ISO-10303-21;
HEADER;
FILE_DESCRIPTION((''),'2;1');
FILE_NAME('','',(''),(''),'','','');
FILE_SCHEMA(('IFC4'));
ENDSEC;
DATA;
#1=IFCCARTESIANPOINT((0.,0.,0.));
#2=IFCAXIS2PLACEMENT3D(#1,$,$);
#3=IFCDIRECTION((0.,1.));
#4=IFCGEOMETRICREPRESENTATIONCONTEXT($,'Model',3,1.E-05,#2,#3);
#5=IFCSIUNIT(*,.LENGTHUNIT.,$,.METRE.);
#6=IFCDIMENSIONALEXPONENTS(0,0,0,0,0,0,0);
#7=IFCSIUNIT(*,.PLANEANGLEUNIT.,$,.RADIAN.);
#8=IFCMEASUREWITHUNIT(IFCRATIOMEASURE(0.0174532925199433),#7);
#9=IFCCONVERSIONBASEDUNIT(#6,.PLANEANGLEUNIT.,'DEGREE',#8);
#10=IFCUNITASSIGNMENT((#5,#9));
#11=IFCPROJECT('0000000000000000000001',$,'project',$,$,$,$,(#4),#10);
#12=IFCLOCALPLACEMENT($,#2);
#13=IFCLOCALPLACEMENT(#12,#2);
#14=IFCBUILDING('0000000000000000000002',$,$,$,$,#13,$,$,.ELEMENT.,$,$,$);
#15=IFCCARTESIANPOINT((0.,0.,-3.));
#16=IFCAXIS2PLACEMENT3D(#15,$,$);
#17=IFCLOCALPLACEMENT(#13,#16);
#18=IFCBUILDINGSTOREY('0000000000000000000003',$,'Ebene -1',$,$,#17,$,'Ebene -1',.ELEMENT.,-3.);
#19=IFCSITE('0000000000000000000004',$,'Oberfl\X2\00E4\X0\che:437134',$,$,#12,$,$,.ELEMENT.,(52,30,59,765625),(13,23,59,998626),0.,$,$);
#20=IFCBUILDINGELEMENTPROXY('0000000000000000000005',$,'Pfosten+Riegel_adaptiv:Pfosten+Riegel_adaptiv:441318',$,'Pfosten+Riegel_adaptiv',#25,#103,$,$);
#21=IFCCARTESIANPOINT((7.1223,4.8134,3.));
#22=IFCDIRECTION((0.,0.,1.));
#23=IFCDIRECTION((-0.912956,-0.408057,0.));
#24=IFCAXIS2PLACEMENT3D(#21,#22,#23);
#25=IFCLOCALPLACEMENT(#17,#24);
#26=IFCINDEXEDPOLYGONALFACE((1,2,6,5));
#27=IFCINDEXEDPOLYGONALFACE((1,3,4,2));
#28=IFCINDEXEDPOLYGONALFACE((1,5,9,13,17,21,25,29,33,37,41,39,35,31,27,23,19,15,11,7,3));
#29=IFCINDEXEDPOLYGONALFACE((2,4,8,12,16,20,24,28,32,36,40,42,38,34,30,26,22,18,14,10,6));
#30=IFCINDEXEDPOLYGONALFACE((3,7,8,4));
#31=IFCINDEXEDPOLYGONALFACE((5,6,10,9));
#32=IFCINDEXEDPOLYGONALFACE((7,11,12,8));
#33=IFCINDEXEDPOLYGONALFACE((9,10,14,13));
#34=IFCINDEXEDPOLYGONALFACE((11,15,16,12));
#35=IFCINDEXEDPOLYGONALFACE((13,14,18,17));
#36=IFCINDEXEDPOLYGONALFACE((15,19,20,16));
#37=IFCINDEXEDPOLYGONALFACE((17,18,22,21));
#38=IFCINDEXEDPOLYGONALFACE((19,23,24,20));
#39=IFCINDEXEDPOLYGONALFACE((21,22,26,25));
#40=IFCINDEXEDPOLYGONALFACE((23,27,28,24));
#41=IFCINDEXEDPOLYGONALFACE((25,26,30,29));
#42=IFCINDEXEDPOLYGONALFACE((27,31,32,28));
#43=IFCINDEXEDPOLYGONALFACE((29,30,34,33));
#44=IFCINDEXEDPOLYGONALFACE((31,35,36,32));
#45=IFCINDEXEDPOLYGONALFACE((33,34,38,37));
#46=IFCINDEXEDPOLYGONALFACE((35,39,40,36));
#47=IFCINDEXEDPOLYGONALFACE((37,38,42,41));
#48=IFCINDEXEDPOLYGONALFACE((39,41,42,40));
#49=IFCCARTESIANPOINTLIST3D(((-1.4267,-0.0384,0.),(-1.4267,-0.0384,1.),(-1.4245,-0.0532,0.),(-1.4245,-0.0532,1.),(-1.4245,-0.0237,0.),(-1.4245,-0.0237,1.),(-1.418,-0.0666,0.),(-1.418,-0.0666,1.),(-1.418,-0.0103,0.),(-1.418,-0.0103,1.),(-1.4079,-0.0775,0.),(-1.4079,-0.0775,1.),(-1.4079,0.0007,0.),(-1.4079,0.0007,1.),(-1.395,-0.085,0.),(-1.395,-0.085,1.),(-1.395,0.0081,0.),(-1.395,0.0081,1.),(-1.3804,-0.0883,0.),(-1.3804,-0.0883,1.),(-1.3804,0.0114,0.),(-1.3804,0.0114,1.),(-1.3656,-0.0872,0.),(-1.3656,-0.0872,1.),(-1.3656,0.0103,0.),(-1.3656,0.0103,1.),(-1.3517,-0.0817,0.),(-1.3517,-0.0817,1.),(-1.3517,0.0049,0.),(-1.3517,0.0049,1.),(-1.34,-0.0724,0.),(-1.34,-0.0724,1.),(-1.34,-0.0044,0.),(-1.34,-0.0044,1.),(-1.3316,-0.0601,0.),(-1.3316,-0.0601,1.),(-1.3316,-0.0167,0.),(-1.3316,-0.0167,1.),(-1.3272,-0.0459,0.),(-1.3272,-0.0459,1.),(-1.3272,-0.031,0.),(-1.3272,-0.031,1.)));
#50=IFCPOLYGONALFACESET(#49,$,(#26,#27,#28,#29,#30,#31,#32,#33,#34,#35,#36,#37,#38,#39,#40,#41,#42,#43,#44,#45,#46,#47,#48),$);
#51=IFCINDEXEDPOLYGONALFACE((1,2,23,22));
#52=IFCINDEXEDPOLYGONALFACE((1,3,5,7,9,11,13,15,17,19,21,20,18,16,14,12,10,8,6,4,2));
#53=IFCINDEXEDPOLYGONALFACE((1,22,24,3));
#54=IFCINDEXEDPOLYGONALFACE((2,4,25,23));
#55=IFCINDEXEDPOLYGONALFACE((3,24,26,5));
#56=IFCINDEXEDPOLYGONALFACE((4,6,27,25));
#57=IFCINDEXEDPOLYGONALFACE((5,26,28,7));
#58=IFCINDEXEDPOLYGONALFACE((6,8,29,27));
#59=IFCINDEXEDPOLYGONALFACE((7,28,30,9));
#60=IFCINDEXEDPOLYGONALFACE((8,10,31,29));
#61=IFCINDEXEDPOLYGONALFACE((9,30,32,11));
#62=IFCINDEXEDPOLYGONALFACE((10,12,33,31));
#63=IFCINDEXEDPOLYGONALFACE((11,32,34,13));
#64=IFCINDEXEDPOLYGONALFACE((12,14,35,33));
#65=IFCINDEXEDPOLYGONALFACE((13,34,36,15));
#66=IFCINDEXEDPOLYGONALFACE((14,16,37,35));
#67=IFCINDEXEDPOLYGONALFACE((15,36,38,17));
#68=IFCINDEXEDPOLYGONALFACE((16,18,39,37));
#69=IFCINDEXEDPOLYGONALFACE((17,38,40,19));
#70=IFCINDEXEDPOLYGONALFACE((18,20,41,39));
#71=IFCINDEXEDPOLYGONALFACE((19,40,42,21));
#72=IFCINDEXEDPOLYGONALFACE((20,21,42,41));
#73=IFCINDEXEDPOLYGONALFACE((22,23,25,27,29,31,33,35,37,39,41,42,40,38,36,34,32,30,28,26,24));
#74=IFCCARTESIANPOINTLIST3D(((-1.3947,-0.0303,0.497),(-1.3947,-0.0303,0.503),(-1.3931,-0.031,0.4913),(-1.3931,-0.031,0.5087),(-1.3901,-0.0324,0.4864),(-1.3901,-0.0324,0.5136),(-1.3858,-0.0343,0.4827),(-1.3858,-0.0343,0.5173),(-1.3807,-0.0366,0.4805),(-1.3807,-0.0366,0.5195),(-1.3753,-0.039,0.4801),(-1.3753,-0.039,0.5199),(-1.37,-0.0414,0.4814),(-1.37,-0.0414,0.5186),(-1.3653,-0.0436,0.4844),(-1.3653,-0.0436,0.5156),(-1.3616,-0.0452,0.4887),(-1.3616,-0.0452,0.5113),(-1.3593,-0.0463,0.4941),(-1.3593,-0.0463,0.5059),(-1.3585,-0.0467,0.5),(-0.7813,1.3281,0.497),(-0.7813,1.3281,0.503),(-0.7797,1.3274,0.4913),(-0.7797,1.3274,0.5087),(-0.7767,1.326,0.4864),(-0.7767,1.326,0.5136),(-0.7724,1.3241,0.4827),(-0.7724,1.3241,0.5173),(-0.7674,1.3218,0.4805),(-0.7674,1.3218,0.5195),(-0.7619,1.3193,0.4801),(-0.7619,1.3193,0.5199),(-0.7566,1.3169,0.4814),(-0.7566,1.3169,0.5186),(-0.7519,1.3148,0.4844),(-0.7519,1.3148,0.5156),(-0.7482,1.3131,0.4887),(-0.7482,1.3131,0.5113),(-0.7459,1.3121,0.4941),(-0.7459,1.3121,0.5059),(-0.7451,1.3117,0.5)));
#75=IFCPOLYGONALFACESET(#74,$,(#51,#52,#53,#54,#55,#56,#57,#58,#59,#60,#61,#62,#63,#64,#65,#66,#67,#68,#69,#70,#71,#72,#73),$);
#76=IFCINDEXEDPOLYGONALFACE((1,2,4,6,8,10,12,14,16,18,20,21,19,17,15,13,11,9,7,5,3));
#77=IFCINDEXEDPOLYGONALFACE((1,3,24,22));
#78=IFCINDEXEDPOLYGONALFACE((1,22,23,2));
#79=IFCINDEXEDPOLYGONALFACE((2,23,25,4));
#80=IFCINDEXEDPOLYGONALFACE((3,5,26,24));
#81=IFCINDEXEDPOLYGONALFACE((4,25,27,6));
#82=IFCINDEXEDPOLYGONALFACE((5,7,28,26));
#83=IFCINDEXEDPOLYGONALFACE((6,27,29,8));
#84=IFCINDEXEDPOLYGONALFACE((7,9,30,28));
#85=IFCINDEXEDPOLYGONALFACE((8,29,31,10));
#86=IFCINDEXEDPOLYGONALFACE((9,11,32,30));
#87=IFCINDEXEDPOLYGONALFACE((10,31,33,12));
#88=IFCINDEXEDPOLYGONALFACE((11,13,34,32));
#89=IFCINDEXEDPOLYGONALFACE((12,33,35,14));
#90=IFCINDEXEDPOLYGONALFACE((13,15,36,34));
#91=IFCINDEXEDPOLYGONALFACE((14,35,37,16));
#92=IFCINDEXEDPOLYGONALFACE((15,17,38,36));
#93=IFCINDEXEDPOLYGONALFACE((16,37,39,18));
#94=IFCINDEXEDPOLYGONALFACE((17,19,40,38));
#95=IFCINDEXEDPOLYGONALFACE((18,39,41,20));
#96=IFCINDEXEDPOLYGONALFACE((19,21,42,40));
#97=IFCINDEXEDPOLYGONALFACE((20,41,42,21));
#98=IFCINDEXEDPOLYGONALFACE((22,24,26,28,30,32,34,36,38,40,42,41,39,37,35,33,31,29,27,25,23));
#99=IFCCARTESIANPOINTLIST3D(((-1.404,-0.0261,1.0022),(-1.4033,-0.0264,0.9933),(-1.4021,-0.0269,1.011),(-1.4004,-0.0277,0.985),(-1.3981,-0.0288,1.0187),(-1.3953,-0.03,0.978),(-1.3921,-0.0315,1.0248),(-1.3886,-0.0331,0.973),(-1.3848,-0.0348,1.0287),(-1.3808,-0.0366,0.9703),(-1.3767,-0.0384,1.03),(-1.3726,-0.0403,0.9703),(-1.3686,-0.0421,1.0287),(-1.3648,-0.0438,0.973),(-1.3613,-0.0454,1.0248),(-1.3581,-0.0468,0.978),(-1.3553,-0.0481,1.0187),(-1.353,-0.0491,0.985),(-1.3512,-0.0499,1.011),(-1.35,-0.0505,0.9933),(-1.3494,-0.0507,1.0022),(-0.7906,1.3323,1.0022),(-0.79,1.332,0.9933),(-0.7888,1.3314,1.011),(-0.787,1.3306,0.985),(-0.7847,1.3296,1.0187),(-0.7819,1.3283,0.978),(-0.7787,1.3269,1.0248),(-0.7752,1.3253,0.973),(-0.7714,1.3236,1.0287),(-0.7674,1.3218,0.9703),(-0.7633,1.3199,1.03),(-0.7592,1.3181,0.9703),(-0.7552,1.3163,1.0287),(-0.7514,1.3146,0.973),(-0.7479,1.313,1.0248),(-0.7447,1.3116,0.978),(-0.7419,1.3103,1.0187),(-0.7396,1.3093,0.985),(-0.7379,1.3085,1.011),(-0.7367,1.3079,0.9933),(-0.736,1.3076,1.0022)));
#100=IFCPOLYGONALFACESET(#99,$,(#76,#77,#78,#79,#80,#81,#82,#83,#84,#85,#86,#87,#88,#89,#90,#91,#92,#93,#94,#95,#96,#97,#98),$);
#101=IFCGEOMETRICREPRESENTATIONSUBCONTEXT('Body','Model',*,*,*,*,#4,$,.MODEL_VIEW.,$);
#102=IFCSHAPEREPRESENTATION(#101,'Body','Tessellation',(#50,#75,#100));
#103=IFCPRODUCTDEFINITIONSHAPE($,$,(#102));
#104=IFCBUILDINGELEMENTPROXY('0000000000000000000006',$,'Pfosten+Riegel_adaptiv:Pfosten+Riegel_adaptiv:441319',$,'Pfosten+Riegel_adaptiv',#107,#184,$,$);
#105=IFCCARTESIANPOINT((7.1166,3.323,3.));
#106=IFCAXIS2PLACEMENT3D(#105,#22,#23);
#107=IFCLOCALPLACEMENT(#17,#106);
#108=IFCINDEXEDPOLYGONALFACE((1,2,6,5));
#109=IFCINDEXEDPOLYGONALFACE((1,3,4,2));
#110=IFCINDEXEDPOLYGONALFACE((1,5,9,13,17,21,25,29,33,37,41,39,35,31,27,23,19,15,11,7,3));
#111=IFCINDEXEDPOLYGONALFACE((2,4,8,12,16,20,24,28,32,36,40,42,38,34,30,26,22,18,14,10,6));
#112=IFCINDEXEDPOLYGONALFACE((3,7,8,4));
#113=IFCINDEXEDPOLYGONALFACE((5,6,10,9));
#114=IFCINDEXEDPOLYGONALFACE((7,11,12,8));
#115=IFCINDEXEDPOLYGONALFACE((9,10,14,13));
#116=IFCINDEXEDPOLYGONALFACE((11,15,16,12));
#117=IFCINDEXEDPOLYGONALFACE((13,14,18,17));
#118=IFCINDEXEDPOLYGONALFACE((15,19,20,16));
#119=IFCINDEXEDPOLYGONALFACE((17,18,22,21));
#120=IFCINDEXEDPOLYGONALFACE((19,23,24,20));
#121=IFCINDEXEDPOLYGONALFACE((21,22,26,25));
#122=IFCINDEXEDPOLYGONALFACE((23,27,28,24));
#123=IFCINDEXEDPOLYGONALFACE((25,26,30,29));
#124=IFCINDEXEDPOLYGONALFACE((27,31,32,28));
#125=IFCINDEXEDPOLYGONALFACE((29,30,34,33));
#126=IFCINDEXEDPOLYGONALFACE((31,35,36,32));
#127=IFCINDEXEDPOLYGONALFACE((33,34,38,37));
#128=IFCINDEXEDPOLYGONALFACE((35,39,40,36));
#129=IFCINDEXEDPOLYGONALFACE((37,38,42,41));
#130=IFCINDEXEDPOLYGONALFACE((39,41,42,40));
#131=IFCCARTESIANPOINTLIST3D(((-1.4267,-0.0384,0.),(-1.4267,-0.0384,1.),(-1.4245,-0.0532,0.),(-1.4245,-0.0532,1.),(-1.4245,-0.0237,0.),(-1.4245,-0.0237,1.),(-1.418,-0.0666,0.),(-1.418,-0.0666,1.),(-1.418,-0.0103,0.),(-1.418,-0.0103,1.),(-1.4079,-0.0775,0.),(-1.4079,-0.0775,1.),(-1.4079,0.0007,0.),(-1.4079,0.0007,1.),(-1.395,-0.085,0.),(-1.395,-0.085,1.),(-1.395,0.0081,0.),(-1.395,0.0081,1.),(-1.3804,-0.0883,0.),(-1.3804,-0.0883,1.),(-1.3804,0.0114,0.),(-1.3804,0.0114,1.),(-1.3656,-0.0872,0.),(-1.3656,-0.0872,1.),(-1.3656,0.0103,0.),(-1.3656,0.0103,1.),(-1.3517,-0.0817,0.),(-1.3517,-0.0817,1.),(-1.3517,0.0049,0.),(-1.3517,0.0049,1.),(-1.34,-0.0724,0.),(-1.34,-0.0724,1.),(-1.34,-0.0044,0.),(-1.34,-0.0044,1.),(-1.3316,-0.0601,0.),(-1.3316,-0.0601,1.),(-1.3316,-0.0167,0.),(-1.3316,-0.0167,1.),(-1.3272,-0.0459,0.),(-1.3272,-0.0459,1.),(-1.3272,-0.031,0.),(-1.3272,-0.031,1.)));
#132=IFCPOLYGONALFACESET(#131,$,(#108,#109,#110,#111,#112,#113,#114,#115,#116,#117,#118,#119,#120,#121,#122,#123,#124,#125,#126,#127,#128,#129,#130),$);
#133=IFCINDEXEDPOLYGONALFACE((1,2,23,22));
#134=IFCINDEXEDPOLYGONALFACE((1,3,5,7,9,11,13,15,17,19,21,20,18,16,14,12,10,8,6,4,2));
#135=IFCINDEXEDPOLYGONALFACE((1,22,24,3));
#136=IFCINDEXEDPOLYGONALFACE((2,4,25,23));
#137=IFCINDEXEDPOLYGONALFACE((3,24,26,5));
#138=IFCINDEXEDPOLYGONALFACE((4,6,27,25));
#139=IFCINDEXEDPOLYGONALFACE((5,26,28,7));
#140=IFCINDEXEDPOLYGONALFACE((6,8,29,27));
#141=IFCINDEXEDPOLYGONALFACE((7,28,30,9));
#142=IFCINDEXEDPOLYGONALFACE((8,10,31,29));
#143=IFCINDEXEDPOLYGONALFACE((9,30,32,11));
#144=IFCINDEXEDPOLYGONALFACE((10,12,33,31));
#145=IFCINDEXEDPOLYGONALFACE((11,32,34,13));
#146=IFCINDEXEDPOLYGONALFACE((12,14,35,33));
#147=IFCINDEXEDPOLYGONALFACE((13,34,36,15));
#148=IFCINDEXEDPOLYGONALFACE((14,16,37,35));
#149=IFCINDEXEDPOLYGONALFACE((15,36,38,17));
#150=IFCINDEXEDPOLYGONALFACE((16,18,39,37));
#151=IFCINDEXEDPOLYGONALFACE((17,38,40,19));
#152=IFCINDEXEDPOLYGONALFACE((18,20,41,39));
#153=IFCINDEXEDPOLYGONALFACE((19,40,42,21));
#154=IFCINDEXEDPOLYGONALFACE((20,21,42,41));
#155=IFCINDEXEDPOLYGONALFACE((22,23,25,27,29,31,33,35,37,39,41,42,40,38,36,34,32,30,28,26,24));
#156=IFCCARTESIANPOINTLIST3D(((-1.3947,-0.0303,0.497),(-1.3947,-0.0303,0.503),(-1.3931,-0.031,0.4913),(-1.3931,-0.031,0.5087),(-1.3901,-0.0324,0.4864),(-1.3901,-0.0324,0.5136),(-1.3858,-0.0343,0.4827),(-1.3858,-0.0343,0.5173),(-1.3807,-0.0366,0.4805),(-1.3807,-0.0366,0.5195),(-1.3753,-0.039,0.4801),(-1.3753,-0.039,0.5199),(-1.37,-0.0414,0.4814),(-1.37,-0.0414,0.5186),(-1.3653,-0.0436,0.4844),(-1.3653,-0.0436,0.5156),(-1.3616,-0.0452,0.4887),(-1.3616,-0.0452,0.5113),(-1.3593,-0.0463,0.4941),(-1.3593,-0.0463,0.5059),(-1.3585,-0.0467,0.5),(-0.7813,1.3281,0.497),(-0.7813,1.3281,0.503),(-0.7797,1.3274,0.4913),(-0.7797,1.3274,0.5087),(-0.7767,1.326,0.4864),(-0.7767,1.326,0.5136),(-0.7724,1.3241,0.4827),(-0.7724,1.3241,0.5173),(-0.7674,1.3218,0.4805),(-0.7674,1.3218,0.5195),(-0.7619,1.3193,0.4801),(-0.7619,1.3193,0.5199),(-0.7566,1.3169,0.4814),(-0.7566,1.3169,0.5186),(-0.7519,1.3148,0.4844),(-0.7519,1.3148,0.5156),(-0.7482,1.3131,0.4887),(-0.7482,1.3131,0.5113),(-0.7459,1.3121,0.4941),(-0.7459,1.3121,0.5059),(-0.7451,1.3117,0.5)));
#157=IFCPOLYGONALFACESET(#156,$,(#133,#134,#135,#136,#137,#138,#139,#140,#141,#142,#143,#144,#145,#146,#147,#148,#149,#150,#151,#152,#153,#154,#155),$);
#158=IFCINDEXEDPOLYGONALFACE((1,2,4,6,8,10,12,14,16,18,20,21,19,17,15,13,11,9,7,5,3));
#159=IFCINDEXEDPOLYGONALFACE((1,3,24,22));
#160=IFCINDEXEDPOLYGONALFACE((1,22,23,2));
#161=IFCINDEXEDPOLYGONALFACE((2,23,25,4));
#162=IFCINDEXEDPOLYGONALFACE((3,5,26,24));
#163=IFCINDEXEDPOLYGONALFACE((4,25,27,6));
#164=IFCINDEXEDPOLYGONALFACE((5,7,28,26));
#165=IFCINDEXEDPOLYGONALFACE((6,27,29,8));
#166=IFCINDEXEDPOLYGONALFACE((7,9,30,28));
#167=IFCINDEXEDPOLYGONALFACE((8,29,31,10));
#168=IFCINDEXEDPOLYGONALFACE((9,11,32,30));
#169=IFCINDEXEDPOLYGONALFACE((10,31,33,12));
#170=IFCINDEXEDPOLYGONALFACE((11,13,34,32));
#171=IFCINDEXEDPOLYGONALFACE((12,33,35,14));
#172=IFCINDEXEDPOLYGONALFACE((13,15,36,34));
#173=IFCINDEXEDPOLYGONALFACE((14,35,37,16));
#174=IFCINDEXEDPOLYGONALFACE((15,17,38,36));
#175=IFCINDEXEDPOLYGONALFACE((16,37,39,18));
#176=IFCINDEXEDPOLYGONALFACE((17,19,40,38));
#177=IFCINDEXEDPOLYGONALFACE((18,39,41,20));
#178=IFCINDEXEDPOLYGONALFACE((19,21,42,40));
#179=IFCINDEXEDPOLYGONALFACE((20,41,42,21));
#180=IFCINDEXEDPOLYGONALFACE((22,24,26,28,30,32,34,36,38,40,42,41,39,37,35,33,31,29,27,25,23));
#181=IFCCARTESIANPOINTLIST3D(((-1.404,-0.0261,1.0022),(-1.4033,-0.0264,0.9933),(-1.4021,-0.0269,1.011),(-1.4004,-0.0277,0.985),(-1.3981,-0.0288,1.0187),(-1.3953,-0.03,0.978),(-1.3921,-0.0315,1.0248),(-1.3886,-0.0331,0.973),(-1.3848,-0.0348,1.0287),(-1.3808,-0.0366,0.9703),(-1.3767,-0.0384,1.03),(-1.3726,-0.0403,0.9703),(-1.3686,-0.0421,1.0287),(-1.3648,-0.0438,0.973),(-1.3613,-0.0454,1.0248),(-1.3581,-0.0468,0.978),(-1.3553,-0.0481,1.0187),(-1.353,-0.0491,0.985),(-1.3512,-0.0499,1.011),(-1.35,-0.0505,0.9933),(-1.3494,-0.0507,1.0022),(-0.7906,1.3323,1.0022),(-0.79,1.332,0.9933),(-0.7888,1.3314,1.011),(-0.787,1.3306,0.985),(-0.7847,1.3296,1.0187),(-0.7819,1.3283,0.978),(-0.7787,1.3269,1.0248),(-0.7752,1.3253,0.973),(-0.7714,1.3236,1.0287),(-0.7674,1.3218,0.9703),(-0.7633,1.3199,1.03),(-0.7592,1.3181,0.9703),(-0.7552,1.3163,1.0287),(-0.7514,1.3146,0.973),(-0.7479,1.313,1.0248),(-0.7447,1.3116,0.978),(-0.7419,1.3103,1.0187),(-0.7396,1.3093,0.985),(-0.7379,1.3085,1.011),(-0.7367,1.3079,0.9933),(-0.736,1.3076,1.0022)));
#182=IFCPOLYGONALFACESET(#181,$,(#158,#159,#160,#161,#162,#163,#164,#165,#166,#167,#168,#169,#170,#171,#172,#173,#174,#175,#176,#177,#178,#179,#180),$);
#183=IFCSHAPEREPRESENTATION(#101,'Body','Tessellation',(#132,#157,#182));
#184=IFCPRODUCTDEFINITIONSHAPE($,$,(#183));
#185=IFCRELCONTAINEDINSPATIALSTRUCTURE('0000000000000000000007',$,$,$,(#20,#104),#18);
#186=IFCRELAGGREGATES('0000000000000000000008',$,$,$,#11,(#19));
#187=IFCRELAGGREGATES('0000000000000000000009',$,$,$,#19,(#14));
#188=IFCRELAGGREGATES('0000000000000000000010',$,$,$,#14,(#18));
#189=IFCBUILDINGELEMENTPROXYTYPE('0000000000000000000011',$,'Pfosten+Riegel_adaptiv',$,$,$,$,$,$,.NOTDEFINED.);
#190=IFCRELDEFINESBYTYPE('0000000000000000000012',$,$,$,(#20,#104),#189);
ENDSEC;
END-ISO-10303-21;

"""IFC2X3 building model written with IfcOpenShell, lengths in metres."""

from ifc_helpers import new_model, entity, si_unit, converted_unit, direction, frame, frame_2d, origin, place, context, subcontext, project, spatial, circle, extrude, source, transform, mapped, type_object, type_shapes, element, save


model = new_model("IFC2X3")

# Units and contexts
model_context = context("Model", 3, precision=1e-05, world=origin(), true_north=direction((0.0, 1.0)))
body_context = subcontext(model_context, "Body", "Model", "MODEL_VIEW")
ifc_project = project(units=[si_unit("LENGTHUNIT", "METRE"), converted_unit("PLANEANGLEUNIT", "DEGREE", entity("IfcRatioMeasure", 0.0174532925199433), si_unit("PLANEANGLEUNIT", "RADIAN"), dimensions=[0, 0, 0, 0, 0, 0, 0])], contexts=[model_context])

# Site, building, storey
site_placement = place(None, origin())
site = spatial("IfcSite", under=ifc_project, at=site_placement, Name="Oberfläche:437134", CompositionType="ELEMENT", RefLatitude=(52, 30, 59, 765625), RefLongitude=(13, 23, 59, 998626), RefElevation=0.0)
building_placement = place(site_placement, origin())
building = spatial("IfcBuilding", under=site, at=building_placement, CompositionType="ELEMENT")
storey_placement = place(building_placement, frame((0.0, 0.0, -3.0)))
storey = spatial("IfcBuildingStorey", under=building, at=storey_placement, Name="Ebene -1", LongName="Ebene -1", CompositionType="ELEMENT", Elevation=-3.0)

# Building element proxies
building_element_proxy_type_1 = type_object("IfcBuildingElementProxyType", Name="Pfosten+Riegel_adaptiv", PredefinedType="NOTDEFINED")
shared_shape_1 = source(origin(), body_context, "Body", "SweptSolid", [
    extrude(circle(Radius=0.05, at=frame_2d((0.0, 0.0), x_axis=(1.0, 0.0))), frame((-1.3767, -0.0384, 0.0), z_axis=(0.0, 0.0, 1.0), x_axis=(-1.0, 0.0, 0.0)), (0.0, 0.0, 1.0), 1.0),
    extrude(circle(Radius=0.02, at=frame_2d((0.0, 0.0), x_axis=(1.0, 0.0))), frame((-1.3767, -0.0384, 0.5), z_axis=(0.411546, 0.911389, 0.0), x_axis=(0.911389, -0.411546, 0.0)), (0.0, 0.0, 1.0), 1.4904),
    extrude(circle(Radius=0.03, at=frame_2d((0.0, 0.0), x_axis=(1.0, 0.0))), frame((-1.3767, -0.0384, 1.0), z_axis=(0.411546, 0.911389, 0.0), x_axis=(0.0, 0.0, 1.0)), (0.0, 0.0, 1.0), 1.4904),
])
type_shapes(building_element_proxy_type_1, [shared_shape_1])
for number, where, z_axis, x_axis, name in (
    (1, (7.1223, 4.8134, 3.0), (0.0, 0.0, 1.0), (-0.912956, -0.408057, 0.0), "Pfosten+Riegel_adaptiv:Pfosten+Riegel_adaptiv:441318"),
    (2, (7.1166, 3.323, 3.0), (0.0, 0.0, 1.0), (-0.912956, -0.408057, 0.0), "Pfosten+Riegel_adaptiv:Pfosten+Riegel_adaptiv:441319"),
):
    element("IfcBuildingElementProxy", number, at=place(storey_placement, frame(where, z_axis=z_axis, x_axis=x_axis)), inside=storey, type_object=building_element_proxy_type_1, Name=name, ObjectType="Pfosten+Riegel_adaptiv", context=body_context, shape_type="MappedRepresentation", body=[
        mapped(shared_shape_1, transform((0.0, 0.0, 0.0), scale=1.0)),
    ])

save(model, "model.ifc")
